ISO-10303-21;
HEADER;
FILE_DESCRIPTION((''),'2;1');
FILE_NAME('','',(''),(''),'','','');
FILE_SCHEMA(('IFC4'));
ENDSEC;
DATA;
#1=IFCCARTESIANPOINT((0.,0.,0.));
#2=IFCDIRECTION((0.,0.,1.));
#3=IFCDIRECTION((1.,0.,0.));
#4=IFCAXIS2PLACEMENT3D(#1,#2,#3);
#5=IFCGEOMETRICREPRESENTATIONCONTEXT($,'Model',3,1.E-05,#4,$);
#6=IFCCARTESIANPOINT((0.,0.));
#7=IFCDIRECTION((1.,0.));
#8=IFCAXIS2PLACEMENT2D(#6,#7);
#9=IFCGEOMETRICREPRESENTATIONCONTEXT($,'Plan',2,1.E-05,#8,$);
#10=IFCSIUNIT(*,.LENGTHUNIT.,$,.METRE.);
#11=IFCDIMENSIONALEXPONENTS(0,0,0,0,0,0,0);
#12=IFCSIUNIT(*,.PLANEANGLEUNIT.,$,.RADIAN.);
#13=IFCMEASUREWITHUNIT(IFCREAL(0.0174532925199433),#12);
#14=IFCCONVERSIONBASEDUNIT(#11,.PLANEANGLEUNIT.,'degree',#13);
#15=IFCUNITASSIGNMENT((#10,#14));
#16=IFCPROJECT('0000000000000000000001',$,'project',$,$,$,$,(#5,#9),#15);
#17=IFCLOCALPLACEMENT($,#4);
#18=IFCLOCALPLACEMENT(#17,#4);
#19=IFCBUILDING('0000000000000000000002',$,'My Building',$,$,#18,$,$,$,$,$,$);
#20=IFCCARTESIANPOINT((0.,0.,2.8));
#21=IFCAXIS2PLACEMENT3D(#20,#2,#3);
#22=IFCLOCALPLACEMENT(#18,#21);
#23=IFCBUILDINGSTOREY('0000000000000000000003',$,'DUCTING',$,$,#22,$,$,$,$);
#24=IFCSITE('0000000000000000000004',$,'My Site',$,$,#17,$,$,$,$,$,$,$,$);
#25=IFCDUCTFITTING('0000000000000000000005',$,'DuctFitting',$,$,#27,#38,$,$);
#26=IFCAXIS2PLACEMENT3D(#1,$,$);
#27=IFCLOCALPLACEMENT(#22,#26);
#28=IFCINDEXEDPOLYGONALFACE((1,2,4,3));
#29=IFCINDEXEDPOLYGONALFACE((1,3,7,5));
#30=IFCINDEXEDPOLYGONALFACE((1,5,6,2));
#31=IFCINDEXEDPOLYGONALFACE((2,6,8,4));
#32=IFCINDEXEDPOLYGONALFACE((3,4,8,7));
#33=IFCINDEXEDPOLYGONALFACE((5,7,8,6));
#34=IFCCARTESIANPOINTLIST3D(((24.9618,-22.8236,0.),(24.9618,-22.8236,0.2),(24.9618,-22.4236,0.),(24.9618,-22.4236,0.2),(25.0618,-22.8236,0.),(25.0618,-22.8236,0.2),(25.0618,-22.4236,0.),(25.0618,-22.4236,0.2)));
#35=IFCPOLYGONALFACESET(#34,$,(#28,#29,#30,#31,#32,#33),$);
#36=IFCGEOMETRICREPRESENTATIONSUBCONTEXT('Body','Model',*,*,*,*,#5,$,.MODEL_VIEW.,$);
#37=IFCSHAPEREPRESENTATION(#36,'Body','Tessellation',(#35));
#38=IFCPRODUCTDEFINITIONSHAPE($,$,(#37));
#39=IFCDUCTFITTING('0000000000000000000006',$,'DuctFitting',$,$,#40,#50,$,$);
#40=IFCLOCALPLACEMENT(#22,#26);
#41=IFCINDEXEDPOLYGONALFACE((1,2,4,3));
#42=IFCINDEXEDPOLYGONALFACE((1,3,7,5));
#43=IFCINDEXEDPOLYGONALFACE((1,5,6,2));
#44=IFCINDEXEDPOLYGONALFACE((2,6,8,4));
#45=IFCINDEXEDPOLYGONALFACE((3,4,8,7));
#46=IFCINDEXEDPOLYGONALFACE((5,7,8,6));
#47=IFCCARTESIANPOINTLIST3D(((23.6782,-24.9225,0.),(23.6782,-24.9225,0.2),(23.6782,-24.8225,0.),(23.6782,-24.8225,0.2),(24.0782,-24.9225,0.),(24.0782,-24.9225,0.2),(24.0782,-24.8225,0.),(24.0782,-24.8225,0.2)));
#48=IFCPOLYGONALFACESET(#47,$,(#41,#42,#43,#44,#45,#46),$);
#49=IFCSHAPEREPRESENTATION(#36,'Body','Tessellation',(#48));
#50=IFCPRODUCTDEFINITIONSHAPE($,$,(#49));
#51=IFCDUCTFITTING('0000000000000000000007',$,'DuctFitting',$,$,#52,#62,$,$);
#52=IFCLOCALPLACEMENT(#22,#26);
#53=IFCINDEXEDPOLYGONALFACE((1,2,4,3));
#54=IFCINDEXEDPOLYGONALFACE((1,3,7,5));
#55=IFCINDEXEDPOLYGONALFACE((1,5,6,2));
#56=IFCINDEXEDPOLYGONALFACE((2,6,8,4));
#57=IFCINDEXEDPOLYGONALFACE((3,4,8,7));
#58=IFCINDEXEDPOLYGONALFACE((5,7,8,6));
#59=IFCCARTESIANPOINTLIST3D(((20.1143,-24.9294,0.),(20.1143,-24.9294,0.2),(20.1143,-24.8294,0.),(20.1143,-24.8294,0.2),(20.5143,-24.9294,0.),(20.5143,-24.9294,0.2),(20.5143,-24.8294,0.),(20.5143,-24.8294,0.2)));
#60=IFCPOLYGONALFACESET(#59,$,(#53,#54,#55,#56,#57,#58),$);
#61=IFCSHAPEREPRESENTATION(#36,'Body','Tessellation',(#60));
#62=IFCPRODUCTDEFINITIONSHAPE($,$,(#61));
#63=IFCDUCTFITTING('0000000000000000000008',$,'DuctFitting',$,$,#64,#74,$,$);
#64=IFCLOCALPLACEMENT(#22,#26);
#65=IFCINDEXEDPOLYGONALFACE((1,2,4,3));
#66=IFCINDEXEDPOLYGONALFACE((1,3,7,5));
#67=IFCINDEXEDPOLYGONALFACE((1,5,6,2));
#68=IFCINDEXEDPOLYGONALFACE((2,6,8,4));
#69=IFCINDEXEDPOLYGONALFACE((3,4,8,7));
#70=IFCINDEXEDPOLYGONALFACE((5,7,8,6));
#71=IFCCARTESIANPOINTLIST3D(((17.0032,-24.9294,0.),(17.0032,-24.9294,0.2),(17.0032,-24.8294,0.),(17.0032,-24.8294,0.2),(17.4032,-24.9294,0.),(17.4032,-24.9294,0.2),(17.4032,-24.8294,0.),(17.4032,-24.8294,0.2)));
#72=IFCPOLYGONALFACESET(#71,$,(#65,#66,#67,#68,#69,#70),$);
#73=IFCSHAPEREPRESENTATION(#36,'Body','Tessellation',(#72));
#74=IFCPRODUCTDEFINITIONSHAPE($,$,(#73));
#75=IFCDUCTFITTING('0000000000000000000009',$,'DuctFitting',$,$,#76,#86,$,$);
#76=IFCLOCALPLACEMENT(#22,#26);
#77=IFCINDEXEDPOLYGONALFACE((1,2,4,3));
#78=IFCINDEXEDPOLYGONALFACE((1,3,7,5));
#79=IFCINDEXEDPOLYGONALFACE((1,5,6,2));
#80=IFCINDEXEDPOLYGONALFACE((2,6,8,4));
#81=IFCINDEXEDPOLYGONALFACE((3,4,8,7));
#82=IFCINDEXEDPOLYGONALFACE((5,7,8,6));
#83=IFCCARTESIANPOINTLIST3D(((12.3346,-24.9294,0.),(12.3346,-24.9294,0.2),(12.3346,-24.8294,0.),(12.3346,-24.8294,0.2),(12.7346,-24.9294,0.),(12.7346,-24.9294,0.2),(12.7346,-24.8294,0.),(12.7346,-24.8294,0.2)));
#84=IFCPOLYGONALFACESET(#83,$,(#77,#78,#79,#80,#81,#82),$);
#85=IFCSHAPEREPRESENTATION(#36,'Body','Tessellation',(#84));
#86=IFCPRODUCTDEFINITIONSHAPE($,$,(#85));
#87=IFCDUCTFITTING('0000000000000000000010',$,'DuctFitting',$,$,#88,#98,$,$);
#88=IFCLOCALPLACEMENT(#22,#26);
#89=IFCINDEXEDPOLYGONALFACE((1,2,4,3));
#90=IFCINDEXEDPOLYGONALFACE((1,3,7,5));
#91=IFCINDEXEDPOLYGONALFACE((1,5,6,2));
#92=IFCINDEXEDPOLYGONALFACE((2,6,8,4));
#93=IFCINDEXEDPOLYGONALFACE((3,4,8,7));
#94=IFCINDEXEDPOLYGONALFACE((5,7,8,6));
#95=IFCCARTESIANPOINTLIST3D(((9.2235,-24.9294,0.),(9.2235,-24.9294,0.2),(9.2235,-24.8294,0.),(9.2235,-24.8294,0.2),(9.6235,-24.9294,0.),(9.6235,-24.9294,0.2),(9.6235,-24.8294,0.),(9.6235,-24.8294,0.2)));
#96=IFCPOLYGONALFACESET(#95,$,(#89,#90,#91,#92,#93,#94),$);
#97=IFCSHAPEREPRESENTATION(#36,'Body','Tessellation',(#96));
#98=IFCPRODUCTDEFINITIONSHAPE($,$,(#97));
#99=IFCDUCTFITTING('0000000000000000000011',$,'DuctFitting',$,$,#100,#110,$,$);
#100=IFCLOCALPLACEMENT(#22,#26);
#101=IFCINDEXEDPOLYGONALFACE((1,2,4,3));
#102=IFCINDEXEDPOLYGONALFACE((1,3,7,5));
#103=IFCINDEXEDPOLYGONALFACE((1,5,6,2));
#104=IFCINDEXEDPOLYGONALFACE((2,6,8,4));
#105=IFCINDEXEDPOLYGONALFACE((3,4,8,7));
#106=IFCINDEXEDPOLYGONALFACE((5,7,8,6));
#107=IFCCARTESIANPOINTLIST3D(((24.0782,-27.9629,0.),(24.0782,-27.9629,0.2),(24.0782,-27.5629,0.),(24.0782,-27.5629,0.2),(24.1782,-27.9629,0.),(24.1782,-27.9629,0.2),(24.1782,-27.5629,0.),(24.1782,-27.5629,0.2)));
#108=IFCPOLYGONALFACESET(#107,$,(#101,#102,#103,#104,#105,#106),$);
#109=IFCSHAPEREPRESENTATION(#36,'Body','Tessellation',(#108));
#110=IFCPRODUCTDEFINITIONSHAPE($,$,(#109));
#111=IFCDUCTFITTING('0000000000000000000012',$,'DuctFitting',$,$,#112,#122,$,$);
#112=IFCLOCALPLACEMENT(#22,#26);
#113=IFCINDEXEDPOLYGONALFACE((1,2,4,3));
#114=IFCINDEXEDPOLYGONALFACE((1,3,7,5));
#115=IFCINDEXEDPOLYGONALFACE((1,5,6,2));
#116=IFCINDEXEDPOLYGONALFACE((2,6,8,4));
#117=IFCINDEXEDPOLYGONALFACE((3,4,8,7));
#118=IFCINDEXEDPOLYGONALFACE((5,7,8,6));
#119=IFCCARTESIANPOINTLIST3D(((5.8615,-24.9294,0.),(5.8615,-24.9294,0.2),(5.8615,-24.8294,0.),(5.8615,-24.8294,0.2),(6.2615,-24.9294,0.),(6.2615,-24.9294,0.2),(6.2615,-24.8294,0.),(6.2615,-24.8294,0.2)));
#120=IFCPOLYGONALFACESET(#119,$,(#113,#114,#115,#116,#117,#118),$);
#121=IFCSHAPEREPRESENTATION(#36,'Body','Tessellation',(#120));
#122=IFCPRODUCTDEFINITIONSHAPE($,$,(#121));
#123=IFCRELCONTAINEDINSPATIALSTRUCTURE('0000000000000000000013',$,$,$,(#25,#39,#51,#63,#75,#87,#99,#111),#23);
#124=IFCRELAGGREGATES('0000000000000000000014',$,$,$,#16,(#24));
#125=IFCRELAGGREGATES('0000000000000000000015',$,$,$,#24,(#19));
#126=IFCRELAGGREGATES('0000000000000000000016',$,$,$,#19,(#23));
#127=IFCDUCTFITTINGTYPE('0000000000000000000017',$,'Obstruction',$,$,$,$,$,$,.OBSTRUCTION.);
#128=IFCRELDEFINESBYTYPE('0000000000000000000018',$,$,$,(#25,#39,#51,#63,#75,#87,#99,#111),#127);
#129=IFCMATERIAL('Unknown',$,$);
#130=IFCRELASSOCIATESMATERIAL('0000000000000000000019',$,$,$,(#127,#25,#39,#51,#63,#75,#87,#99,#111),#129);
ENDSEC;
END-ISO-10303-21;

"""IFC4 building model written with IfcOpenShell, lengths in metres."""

from ifc_helpers import new_model, entity, si_unit, converted_unit, frame, origin_with_axes, origin_2d_with_axis, place, context, subcontext, project, spatial, rectangle, extrude, material, material_profile, profile_set, profile_usage, type_object, element, save


model = new_model("IFC4")

# Units and contexts
model_context = context("Model", 3, precision=1e-05, world=origin_with_axes())
plan_context = context("Plan", 2, precision=1e-05, world=origin_2d_with_axis())
body_context = subcontext(model_context, "Body", "Model", "MODEL_VIEW")
ifc_project = project(units=[si_unit("LENGTHUNIT", "METRE"), converted_unit("PLANEANGLEUNIT", "degree", entity("IfcReal", 0.0174532925199433), si_unit("PLANEANGLEUNIT", "RADIAN"), dimensions=[0, 0, 0, 0, 0, 0, 0])], contexts=[model_context, plan_context])

# Site, building, storey
site_placement = place(None, origin_with_axes())
site = spatial("IfcSite", under=ifc_project, at=site_placement, Name="My Site")
building_placement = place(site_placement, origin_with_axes())
building = spatial("IfcBuilding", under=site, at=building_placement, Name="My Building")
storey_placement = place(building_placement, frame((0.0, 0.0, 2.8), z_axis=(0.0, 0.0, 1.0), x_axis=(1.0, 0.0, 0.0)))
storey = spatial("IfcBuildingStorey", under=building, at=storey_placement, Name="DUCTING")

# Shared definitions
ifc_material = material(Name="Unknown")

# Duct fittings
ifc_material_profile_1 = material_profile(ifc_material, rectangle(XDim=0.4, YDim=0.2))
ifc_profile_set_1 = profile_set([ifc_material_profile_1])
duct_fitting_type_1 = type_object("IfcDuctFittingType", Name="Obstruction", PredefinedType="OBSTRUCTION", material=ifc_profile_set_1)
ifc_profile_usage_1 = profile_usage(ifc_profile_set_1, cardinal=5)
duct_fitting_1_placement = place(storey_placement, frame((24.9618, -22.6236, 0.1), z_axis=(1.0, 0.0, 0.0), x_axis=(0.0, 1.0, 0.0)))
element("IfcDuctFitting", 1, at=duct_fitting_1_placement, inside=storey, type_object=duct_fitting_type_1, material=ifc_profile_usage_1, Name="DuctFitting", context=body_context, shape_type="SweptSolid", body=[
    extrude(rectangle(XDim=0.4, YDim=0.2), origin_with_axes(), (0.0, 0.0, 1.0), 0.1),
])
ifc_profile_usage_2 = profile_usage(ifc_profile_set_1, cardinal=5)
duct_fitting_2_placement = place(storey_placement, frame((23.8782, -24.8225, 0.1), z_axis=(0.0, -1.0, 0.0), x_axis=(1.0, 0.0, 0.0)))
element("IfcDuctFitting", 2, at=duct_fitting_2_placement, inside=storey, type_object=duct_fitting_type_1, material=ifc_profile_usage_2, Name="DuctFitting", context=body_context, shape_type="SweptSolid", body=[
    extrude(rectangle(XDim=0.4, YDim=0.2), origin_with_axes(), (0.0, 0.0, 1.0), 0.1),
])
ifc_profile_usage_3 = profile_usage(ifc_profile_set_1, cardinal=5)
duct_fitting_3_placement = place(storey_placement, frame((20.3143, -24.8294, 0.1), z_axis=(0.0, -1.0, 0.0), x_axis=(1.0, 0.0, 0.0)))
element("IfcDuctFitting", 3, at=duct_fitting_3_placement, inside=storey, type_object=duct_fitting_type_1, material=ifc_profile_usage_3, Name="DuctFitting", context=body_context, shape_type="SweptSolid", body=[
    extrude(rectangle(XDim=0.4, YDim=0.2), origin_with_axes(), (0.0, 0.0, 1.0), 0.1),
])
ifc_profile_usage_4 = profile_usage(ifc_profile_set_1, cardinal=5)
duct_fitting_4_placement = place(storey_placement, frame((17.2032, -24.8294, 0.1), z_axis=(0.0, -1.0, 0.0), x_axis=(1.0, 0.0, 0.0)))
element("IfcDuctFitting", 4, at=duct_fitting_4_placement, inside=storey, type_object=duct_fitting_type_1, material=ifc_profile_usage_4, Name="DuctFitting", context=body_context, shape_type="SweptSolid", body=[
    extrude(rectangle(XDim=0.4, YDim=0.2), origin_with_axes(), (0.0, 0.0, 1.0), 0.1),
])
ifc_profile_usage_5 = profile_usage(ifc_profile_set_1, cardinal=5)
duct_fitting_5_placement = place(storey_placement, frame((12.5346, -24.8294, 0.1), z_axis=(0.0, -1.0, 0.0), x_axis=(1.0, 0.0, 0.0)))
element("IfcDuctFitting", 5, at=duct_fitting_5_placement, inside=storey, type_object=duct_fitting_type_1, material=ifc_profile_usage_5, Name="DuctFitting", context=body_context, shape_type="SweptSolid", body=[
    extrude(rectangle(XDim=0.4, YDim=0.2), origin_with_axes(), (0.0, 0.0, 1.0), 0.1),
])
ifc_profile_usage_6 = profile_usage(ifc_profile_set_1, cardinal=5)
duct_fitting_6_placement = place(storey_placement, frame((9.4235, -24.8294, 0.1), z_axis=(0.0, -1.0, 0.0), x_axis=(1.0, 0.0, 0.0)))
element("IfcDuctFitting", 6, at=duct_fitting_6_placement, inside=storey, type_object=duct_fitting_type_1, material=ifc_profile_usage_6, Name="DuctFitting", context=body_context, shape_type="SweptSolid", body=[
    extrude(rectangle(XDim=0.4, YDim=0.2), origin_with_axes(), (0.0, 0.0, 1.0), 0.1),
])
ifc_profile_usage_7 = profile_usage(ifc_profile_set_1, cardinal=5)
duct_fitting_7_placement = place(storey_placement, frame((24.0782, -27.7629, 0.1), z_axis=(1.0, -0.000001, 0.000001), x_axis=(0.000001, 1.0, 0.0)))
element("IfcDuctFitting", 7, at=duct_fitting_7_placement, inside=storey, type_object=duct_fitting_type_1, material=ifc_profile_usage_7, Name="DuctFitting", context=body_context, shape_type="SweptSolid", body=[
    extrude(rectangle(XDim=0.4, YDim=0.2), origin_with_axes(), (0.0, 0.0, 1.0), 0.1),
])
ifc_profile_usage_8 = profile_usage(ifc_profile_set_1, cardinal=5)
duct_fitting_8_placement = place(storey_placement, frame((6.0615, -24.8294, 0.1), z_axis=(0.0, -1.0, 0.0), x_axis=(1.0, 0.0, 0.0)))
element("IfcDuctFitting", 8, at=duct_fitting_8_placement, inside=storey, type_object=duct_fitting_type_1, material=ifc_profile_usage_8, Name="DuctFitting", context=body_context, shape_type="SweptSolid", body=[
    extrude(rectangle(XDim=0.4, YDim=0.2), origin_with_axes(), (0.0, 0.0, 1.0), 0.1),
])

save(model, "model.ifc")
